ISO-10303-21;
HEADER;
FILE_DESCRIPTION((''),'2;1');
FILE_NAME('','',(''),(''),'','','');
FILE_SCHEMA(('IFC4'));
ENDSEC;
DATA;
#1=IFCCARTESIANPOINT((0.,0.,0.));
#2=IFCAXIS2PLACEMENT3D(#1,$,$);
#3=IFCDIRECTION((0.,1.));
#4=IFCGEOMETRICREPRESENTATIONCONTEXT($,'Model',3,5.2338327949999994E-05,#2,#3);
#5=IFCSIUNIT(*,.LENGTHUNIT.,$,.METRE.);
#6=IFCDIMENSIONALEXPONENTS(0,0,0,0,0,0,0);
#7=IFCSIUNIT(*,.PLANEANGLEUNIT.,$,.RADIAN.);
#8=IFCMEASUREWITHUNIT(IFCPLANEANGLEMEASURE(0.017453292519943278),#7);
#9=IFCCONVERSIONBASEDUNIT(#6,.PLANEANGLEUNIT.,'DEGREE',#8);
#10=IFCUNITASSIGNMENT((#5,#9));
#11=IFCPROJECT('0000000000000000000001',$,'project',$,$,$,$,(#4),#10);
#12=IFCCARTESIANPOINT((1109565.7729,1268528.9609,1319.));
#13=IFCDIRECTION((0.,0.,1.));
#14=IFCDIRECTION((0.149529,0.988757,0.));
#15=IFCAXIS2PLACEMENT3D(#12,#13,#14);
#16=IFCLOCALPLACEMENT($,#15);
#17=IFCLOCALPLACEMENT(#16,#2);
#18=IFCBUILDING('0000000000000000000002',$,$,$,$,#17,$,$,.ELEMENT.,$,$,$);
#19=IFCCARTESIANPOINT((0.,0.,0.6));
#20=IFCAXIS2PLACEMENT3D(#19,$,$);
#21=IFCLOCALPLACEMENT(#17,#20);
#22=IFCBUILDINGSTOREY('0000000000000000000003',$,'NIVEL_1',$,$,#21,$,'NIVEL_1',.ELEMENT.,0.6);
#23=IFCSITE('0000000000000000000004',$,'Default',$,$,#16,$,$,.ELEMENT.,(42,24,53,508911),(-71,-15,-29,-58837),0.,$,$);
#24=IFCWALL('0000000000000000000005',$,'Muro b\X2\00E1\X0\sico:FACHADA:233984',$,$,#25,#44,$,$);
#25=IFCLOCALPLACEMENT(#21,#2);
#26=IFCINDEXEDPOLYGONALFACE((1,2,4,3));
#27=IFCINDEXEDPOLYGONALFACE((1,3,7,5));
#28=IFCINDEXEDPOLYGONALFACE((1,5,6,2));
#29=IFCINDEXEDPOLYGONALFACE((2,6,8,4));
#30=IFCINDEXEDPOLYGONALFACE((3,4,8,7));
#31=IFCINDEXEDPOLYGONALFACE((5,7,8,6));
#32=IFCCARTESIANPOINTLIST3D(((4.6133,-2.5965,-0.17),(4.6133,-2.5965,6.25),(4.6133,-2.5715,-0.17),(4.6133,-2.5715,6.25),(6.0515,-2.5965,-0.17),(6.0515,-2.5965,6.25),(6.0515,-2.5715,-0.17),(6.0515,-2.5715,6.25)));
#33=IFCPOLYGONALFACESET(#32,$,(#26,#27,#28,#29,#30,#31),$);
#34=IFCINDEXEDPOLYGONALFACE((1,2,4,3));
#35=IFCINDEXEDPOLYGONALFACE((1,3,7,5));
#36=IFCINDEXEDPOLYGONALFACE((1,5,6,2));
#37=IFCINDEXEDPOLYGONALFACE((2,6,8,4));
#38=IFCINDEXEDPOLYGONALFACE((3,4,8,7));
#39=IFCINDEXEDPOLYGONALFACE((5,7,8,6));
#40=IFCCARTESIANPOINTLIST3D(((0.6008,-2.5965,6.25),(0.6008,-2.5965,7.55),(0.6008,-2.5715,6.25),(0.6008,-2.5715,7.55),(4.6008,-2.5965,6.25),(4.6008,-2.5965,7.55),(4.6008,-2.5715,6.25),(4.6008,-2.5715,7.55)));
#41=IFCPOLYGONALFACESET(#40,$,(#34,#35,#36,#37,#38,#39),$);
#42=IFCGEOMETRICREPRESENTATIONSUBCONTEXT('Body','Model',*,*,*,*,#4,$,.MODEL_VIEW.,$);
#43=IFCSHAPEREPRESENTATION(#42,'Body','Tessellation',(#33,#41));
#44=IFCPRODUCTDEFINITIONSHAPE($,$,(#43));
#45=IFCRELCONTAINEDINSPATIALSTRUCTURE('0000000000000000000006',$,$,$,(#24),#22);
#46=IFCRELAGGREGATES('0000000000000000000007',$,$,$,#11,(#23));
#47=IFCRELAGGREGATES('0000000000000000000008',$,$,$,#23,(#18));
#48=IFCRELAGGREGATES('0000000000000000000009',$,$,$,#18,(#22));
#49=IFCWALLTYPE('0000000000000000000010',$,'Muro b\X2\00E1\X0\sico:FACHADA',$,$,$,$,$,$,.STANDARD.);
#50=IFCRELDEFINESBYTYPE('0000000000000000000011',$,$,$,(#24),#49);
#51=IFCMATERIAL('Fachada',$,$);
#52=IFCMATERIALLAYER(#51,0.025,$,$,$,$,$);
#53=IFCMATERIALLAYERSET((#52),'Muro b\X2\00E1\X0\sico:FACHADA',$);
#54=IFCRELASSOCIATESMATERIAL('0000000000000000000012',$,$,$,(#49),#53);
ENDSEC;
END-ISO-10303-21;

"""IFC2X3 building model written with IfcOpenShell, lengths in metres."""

from ifc_helpers import new_model, entity, si_unit, converted_unit, direction, frame, frame_2d, origin, place, context, subcontext, project, spatial, rectangle, extrude, material, layer, layer_set, type_object, element, save


model = new_model("IFC2X3")

# Units and contexts
model_context = context("Model", 3, precision=5.2338327949999994e-05, world=origin(), true_north=direction((0.0, 1.0)))
body_context = subcontext(model_context, "Body", "Model", "MODEL_VIEW")
ifc_project = project(units=[si_unit("LENGTHUNIT", "METRE"), converted_unit("PLANEANGLEUNIT", "DEGREE", entity("IfcPlaneAngleMeasure", 0.017453292519943278), si_unit("PLANEANGLEUNIT", "RADIAN"), dimensions=[0, 0, 0, 0, 0, 0, 0])], contexts=[model_context])

# Site, building, storey
site_placement = place(None, frame((1109565.7729, 1268528.9609, 1319.0), z_axis=(0.0, 0.0, 1.0), x_axis=(0.149529, 0.988757, 0.0)))
site = spatial("IfcSite", under=ifc_project, at=site_placement, Name="Default", CompositionType="ELEMENT", RefLatitude=(42, 24, 53, 508911), RefLongitude=(-71, -15, -29, -58837), RefElevation=0.0)
building_placement = place(site_placement, origin())
building = spatial("IfcBuilding", under=site, at=building_placement, CompositionType="ELEMENT")
storey_placement = place(building_placement, frame((0.0, 0.0, 0.6)))
storey = spatial("IfcBuildingStorey", under=building, at=storey_placement, Name="NIVEL_1", LongName="NIVEL_1", CompositionType="ELEMENT", Elevation=0.6)

# Shared definitions
ifc_material_1 = material(Name="Fachada")
ifc_layer_1 = layer(ifc_material_1, 0.025)
ifc_layer_set_1 = layer_set([ifc_layer_1], Name="Muro básico:FACHADA")
wall_type_1 = type_object("IfcWallType", Name="Muro básico:FACHADA", PredefinedType="STANDARD", material=ifc_layer_set_1)

# Wall
wall_1_placement = place(storey_placement, frame((6.0515, -2.584, -0.17), z_axis=(0.0, 0.0, 1.0), x_axis=(-1.0, 0.0, 0.0)))
element("IfcWall", 1, at=wall_1_placement, inside=storey, type_object=wall_type_1, Name="Muro básico:FACHADA:233984", context=body_context, shape_type="SweptSolid", body=[
    extrude(rectangle(XDim=0.025, YDim=1.4382, at=frame_2d((0.0, 0.0), x_axis=(1.0, 0.0))), frame((0.7191, 0.0, 0.0), z_axis=(0.0, 0.0, 1.0), x_axis=(0.0, 1.0, 0.0)), (0.0, 0.0, 1.0), 6.42),
    extrude(rectangle(XDim=0.025, YDim=4.0, at=frame_2d((0.0, 0.0), x_axis=(1.0, 0.0))), frame((3.4507, 0.0, 6.42), z_axis=(0.0, 0.0, 1.0), x_axis=(0.0, 1.0, 0.0)), (0.0, 0.0, 1.0), 1.3),
])

save(model, "model.ifc")
